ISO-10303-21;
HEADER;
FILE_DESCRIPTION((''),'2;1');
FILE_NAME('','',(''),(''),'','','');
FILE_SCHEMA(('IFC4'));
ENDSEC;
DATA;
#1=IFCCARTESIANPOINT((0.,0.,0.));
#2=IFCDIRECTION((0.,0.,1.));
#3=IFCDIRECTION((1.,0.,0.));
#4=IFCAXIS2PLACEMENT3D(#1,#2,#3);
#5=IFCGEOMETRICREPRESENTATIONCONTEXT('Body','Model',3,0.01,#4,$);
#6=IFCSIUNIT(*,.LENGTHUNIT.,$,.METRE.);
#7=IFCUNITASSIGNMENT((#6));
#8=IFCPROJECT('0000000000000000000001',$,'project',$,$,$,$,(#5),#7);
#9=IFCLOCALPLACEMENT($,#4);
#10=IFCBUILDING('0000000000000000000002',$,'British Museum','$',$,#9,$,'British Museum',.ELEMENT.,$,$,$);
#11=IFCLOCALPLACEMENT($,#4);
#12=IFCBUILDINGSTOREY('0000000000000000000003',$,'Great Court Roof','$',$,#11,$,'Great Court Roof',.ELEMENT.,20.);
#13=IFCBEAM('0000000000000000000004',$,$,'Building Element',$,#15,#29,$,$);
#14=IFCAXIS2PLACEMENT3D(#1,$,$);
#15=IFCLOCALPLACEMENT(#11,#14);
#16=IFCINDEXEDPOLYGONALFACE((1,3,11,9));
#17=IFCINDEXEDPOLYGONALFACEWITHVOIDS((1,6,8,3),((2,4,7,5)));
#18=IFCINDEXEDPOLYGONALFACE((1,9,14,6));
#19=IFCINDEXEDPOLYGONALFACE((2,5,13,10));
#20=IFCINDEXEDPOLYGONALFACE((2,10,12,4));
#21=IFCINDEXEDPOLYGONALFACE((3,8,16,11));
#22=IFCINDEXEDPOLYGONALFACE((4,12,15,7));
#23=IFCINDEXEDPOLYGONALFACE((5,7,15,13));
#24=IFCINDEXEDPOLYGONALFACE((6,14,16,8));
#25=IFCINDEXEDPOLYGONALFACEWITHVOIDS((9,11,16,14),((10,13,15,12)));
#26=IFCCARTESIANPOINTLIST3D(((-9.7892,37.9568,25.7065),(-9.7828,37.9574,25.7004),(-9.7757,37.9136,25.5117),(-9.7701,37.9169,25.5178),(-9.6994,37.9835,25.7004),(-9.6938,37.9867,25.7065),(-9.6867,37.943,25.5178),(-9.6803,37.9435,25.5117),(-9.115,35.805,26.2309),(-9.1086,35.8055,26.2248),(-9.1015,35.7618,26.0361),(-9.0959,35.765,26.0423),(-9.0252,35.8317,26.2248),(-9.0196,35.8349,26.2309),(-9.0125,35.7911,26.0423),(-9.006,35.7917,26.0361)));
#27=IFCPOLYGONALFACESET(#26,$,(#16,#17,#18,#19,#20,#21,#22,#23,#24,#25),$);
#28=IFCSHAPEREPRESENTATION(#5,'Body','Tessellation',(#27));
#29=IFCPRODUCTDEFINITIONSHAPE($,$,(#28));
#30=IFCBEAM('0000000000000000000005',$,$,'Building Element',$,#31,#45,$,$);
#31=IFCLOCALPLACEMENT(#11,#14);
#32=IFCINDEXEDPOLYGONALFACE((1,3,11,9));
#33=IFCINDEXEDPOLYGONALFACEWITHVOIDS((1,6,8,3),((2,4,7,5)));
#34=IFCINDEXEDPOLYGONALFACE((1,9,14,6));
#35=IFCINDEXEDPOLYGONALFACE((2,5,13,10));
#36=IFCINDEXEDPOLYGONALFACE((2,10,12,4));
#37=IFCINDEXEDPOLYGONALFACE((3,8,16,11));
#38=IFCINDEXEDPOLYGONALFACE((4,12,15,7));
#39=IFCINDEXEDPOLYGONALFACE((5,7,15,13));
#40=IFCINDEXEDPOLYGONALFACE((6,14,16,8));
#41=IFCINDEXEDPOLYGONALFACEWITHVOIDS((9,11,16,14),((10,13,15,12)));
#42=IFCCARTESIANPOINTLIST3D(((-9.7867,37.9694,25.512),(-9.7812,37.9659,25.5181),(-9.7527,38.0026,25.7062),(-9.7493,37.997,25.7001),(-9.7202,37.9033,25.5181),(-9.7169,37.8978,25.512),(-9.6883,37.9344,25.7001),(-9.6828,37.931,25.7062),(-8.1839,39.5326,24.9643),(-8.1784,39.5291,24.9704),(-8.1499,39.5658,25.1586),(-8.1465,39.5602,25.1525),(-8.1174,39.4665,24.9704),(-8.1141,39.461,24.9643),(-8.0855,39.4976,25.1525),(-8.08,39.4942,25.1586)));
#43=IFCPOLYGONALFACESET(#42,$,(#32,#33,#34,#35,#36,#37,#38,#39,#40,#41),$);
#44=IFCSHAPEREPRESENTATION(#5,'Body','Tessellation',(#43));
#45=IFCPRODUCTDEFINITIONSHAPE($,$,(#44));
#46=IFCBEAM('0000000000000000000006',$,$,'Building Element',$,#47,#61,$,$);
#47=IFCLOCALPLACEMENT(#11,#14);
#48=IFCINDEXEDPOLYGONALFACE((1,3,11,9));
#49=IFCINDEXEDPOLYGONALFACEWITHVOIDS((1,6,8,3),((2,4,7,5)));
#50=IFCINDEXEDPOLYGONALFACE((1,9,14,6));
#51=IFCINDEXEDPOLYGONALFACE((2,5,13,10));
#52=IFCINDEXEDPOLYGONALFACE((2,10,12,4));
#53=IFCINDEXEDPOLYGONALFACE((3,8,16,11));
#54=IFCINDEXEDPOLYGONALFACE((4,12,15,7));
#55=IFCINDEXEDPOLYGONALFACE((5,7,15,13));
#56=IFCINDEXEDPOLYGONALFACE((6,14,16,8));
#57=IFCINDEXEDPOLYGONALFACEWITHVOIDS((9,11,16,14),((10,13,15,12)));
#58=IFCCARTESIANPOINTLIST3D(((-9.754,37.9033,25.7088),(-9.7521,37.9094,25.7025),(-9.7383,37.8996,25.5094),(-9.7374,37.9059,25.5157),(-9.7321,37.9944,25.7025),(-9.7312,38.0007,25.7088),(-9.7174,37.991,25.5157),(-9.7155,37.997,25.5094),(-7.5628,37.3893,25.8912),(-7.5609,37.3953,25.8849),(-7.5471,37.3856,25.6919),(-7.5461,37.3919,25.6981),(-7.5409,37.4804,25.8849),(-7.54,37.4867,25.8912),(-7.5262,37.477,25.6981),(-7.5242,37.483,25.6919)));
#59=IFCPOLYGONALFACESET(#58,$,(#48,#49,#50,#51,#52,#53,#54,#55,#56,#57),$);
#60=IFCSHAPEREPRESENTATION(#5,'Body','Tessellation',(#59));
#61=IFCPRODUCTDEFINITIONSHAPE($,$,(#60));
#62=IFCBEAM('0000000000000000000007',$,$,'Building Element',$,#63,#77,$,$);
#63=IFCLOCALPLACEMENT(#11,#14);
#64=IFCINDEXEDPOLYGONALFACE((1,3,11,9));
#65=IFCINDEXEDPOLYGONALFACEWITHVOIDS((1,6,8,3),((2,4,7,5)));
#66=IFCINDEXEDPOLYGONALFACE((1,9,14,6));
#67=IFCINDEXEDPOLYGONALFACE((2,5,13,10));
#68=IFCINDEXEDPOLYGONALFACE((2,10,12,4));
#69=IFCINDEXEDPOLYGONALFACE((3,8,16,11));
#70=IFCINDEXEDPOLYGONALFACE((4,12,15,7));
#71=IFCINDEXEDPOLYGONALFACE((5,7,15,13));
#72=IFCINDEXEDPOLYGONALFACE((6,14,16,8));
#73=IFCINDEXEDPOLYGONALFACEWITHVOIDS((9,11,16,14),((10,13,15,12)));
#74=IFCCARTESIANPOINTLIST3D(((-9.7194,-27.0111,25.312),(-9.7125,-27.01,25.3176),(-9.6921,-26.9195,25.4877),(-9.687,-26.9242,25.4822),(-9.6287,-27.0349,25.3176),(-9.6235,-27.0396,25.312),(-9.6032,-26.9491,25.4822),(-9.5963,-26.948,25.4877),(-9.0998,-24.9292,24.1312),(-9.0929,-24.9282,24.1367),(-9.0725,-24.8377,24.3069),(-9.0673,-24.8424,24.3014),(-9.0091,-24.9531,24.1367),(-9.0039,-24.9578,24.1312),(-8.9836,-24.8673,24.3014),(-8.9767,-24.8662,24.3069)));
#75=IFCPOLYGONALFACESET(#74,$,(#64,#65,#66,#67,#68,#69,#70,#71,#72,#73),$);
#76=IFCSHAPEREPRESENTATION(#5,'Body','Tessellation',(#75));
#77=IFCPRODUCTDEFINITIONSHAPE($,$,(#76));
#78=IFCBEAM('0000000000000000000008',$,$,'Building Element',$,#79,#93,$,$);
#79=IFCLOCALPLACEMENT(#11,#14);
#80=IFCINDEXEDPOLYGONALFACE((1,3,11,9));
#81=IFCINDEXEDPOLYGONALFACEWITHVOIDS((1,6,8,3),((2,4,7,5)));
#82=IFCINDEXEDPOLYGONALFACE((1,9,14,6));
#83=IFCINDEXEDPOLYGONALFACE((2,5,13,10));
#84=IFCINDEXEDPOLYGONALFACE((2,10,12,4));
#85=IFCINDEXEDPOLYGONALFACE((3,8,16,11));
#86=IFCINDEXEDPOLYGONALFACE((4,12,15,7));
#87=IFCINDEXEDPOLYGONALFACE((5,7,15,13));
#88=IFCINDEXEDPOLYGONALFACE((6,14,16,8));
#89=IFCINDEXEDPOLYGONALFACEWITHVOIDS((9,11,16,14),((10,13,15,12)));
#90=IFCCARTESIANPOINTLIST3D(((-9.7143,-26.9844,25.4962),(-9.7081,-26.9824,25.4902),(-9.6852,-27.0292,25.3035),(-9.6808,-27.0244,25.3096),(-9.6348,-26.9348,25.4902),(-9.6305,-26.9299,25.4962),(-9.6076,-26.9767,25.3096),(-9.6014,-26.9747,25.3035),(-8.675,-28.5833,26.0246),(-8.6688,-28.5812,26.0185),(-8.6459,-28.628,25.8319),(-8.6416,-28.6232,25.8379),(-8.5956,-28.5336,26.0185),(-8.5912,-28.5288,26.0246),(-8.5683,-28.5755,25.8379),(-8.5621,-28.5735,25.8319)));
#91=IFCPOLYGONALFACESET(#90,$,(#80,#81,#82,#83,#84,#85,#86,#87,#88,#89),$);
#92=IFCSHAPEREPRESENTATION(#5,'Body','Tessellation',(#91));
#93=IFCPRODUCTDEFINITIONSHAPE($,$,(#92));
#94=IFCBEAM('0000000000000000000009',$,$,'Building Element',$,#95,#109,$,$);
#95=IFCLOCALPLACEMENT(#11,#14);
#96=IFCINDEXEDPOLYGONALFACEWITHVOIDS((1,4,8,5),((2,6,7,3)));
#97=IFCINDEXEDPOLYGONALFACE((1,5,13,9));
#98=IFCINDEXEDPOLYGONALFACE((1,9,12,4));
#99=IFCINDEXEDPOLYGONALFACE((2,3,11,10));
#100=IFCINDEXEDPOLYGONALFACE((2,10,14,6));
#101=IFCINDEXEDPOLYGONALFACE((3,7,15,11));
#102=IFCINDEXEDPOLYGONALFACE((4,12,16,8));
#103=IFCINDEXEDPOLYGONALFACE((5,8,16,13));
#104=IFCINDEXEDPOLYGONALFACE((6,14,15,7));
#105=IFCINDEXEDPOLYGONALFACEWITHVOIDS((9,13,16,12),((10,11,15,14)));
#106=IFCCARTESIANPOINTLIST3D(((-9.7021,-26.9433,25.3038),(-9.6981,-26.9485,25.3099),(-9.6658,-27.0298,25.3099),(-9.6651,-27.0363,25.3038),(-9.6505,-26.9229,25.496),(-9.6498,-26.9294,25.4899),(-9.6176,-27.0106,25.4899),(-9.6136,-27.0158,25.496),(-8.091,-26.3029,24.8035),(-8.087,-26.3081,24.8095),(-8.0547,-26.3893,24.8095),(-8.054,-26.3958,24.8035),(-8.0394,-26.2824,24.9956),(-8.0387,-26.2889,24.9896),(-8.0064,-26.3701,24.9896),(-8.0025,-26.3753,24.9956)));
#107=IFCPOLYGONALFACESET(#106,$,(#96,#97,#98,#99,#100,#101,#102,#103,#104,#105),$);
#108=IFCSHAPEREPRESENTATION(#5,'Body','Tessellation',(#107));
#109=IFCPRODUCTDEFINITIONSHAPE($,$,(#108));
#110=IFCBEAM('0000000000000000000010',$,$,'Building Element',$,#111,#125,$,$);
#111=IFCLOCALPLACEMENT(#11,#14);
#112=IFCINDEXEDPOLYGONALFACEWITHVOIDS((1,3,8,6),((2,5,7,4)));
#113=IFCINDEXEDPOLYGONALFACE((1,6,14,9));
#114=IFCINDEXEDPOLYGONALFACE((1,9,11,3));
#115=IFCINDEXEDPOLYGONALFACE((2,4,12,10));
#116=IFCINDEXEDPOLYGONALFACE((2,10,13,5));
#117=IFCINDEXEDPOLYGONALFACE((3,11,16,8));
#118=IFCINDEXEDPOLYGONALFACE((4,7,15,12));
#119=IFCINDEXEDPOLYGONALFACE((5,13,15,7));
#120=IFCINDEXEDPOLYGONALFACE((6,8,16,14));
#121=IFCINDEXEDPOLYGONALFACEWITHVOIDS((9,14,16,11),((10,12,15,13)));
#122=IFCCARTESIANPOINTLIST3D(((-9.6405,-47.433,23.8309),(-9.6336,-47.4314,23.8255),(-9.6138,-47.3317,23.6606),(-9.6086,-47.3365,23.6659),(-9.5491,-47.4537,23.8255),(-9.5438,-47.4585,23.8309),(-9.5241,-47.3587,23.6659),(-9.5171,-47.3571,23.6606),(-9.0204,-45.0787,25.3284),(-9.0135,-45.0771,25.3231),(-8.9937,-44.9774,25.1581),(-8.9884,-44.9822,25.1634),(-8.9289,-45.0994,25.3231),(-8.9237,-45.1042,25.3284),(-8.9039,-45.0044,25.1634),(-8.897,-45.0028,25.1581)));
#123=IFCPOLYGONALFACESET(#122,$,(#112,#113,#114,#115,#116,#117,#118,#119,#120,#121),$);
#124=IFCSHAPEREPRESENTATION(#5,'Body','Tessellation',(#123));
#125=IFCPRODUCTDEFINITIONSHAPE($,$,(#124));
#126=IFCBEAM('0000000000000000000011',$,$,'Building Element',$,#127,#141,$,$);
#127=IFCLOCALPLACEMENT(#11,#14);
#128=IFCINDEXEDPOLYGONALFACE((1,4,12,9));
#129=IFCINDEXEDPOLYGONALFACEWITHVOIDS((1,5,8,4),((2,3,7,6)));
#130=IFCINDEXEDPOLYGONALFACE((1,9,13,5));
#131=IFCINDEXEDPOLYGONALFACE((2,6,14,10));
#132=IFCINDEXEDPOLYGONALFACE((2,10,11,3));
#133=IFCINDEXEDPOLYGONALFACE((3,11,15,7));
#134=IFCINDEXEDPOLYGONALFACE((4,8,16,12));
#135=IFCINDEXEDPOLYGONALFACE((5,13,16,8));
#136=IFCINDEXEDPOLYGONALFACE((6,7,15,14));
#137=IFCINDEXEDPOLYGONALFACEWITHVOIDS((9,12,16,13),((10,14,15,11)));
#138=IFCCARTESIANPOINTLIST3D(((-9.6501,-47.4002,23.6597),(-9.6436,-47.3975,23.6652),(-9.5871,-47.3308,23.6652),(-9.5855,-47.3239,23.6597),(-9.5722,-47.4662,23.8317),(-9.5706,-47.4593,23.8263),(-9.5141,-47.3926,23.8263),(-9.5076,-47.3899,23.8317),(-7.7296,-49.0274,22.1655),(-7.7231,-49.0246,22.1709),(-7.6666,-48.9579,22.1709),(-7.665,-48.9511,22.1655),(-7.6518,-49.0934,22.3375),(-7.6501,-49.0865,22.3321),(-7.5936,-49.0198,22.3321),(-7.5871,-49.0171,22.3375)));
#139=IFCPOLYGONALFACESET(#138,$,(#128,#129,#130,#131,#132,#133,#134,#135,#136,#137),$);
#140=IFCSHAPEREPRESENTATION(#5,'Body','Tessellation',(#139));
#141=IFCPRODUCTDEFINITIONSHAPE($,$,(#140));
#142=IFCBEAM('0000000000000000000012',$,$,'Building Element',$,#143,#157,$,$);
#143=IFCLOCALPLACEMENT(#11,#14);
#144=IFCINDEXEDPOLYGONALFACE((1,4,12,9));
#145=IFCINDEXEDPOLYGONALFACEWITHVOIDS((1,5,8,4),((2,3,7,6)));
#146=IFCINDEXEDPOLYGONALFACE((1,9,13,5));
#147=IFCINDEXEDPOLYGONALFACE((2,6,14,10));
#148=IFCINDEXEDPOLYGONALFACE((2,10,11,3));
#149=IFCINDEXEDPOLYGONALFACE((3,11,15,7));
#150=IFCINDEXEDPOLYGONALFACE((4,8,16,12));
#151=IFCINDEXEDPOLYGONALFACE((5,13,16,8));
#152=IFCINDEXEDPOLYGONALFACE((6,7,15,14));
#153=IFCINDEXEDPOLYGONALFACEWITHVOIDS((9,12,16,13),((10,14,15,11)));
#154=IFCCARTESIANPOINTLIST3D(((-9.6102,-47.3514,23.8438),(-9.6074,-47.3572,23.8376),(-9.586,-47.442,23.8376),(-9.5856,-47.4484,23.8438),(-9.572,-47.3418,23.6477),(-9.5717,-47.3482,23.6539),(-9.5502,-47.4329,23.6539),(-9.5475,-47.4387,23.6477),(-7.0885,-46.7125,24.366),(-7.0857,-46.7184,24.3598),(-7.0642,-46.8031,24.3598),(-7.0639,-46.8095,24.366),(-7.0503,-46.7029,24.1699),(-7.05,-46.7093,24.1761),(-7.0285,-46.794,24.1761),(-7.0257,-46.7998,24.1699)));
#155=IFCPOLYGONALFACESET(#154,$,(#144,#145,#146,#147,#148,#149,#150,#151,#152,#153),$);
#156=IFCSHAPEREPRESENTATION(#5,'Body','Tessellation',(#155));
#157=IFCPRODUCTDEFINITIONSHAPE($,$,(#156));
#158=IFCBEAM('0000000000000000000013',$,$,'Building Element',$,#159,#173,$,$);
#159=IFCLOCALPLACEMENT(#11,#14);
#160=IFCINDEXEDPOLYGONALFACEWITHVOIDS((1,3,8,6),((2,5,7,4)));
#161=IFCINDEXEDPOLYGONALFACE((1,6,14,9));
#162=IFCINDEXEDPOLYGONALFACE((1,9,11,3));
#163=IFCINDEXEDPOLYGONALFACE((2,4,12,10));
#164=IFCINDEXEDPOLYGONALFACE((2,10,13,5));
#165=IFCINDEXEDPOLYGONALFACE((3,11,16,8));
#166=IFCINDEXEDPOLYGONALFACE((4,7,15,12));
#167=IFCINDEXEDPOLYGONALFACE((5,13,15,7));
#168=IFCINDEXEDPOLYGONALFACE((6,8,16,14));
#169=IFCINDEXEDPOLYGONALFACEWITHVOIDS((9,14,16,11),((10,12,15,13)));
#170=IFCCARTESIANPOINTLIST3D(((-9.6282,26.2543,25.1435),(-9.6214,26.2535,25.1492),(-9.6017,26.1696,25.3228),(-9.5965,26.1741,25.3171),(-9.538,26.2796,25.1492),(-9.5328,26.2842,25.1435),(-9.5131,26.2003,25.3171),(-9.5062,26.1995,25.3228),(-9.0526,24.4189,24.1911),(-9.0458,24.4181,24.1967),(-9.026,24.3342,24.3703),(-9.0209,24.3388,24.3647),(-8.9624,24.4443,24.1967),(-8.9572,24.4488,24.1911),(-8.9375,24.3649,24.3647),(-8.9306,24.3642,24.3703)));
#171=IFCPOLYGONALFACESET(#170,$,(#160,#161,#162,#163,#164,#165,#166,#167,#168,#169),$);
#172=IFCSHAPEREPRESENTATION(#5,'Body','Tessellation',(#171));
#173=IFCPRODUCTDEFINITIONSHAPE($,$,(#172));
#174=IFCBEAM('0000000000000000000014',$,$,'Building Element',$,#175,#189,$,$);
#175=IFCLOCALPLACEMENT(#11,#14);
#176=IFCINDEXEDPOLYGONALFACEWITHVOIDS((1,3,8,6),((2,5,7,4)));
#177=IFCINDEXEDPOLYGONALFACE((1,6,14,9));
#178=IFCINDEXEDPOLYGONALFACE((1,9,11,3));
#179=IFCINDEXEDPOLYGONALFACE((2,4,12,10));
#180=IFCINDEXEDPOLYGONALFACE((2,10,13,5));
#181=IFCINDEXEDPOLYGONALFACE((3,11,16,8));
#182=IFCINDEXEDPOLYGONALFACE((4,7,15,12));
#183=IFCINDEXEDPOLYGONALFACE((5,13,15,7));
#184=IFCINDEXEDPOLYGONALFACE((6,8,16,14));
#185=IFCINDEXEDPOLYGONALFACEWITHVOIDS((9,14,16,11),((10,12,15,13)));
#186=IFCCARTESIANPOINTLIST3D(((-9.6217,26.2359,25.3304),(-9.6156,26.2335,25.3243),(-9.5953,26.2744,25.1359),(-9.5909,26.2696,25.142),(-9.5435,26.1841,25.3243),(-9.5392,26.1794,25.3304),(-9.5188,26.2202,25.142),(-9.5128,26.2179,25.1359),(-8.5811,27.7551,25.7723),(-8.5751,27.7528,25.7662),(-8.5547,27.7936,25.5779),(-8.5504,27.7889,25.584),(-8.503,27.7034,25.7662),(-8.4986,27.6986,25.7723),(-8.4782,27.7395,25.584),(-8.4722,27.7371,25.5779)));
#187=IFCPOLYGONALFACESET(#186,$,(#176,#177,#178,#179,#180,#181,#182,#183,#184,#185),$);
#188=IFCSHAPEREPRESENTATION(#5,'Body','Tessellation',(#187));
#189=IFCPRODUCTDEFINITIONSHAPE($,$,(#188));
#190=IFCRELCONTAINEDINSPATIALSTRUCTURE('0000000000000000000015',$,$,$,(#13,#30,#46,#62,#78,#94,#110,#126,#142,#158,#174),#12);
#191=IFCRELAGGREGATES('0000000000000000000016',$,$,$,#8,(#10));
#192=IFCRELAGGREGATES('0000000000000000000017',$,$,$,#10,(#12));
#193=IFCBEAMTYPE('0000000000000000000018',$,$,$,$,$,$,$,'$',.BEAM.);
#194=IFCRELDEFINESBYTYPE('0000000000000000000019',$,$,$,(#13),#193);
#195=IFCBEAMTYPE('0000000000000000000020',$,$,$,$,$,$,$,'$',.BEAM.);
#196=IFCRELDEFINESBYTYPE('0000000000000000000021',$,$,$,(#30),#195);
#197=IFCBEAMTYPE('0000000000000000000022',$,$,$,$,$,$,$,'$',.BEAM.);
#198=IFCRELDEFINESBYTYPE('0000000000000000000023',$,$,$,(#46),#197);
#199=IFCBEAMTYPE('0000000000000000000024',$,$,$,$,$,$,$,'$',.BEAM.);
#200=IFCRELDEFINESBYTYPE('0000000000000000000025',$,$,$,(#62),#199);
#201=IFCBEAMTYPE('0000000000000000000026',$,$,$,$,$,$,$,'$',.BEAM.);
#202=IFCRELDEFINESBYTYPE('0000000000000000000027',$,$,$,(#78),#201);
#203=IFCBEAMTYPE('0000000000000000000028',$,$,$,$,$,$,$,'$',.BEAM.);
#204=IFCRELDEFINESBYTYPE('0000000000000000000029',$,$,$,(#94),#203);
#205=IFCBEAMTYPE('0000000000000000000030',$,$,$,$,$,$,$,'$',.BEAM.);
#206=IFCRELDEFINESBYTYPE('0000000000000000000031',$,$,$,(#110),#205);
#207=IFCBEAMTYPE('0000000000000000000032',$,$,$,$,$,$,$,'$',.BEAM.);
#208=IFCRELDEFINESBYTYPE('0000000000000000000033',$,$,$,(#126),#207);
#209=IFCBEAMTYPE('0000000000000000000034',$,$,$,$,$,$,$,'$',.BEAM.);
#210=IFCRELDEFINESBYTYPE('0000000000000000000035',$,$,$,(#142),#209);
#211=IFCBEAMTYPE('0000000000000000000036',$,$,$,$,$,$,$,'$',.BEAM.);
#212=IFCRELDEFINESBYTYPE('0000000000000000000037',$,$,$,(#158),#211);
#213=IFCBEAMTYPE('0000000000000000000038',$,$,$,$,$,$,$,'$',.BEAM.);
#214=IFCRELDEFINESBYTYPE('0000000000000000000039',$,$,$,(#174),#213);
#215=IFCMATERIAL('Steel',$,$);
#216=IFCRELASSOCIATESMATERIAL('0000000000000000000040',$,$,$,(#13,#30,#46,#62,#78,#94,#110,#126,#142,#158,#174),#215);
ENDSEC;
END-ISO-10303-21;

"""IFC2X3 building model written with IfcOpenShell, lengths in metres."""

from ifc_helpers import new_model, si_unit, frame, origin_with_axes, origin_2d, place, context, project, spatial, hollow_rectangle, extrude, material, type_object, element, save


model = new_model("IFC2X3")

# Units and contexts
model_context = context("Model", 3, precision=0.01, world=origin_with_axes(), identifier="Body")
ifc_project = project(units=[si_unit("LENGTHUNIT", "METRE")], contexts=[model_context])

# Building, storey
building_placement = place(None, origin_with_axes())
building = spatial("IfcBuilding", under=ifc_project, at=building_placement, Name="British Museum", Description="$", LongName="British Museum", CompositionType="ELEMENT")
storey_placement = place(None, origin_with_axes())
storey = spatial("IfcBuildingStorey", under=building, at=storey_placement, Name="Great Court Roof", Description="$", LongName="Great Court Roof", CompositionType="ELEMENT", Elevation=20.0)

# Beams
ifc_material = material(Name="Steel")
beam_type_1 = type_object("IfcBeamType", ElementType="$", PredefinedType="BEAM")
beam_1_placement = place(None, origin_with_axes())
element("IfcBeam", 1, at=beam_1_placement, inside=storey, type_object=beam_type_1, material=ifc_material, Description="Building Element", context=model_context, shape_type="SweptSolid", body=[
    extrude(hollow_rectangle(XDim=0.1, YDim=0.2, WallThickness=0.0063, InnerFilletRadius=-0.0063, OuterFilletRadius=0.0, at=origin_2d()), frame((-9.7348, 37.9502, 25.6091), z_axis=(0.291229, -0.92945, 0.226512), x_axis=(0.954253, 0.299001, 0.0)), (0.0, 0.0, 1.0), 2.3152),
])
beam_type_2 = type_object("IfcBeamType", ElementType="$", PredefinedType="BEAM")
beam_2_placement = place(None, origin_with_axes())
element("IfcBeam", 2, at=beam_2_placement, inside=storey, type_object=beam_type_2, material=ifc_material, Description="Building Element", context=model_context, shape_type="SweptSolid", body=[
    extrude(hollow_rectangle(XDim=0.1, YDim=0.2, WallThickness=0.0063, InnerFilletRadius=-0.0063, OuterFilletRadius=0.0, at=origin_2d()), frame((-9.7348, 37.9502, 25.6091), z_axis=(0.695394, 0.67821, -0.237611), x_axis=(-0.698206, 0.715897, 0.0)), (0.0, 0.0, 1.0), 2.3049),
])
beam_type_3 = type_object("IfcBeamType", ElementType="$", PredefinedType="BEAM")
beam_3_placement = place(None, origin_with_axes())
element("IfcBeam", 3, at=beam_3_placement, inside=storey, type_object=beam_type_3, material=ifc_material, Description="Building Element", context=model_context, shape_type="SweptSolid", body=[
    extrude(hollow_rectangle(XDim=0.1, YDim=0.2, WallThickness=0.0063, InnerFilletRadius=-0.0063, OuterFilletRadius=0.0, at=origin_2d()), frame((-9.7348, 37.9502, 25.6091), z_axis=(0.970391, -0.227631, 0.080786), x_axis=(0.228377, 0.973573, 0.0)), (0.0, 0.0, 1.0), 2.2581),
])
beam_type_4 = type_object("IfcBeamType", ElementType="$", PredefinedType="BEAM")
beam_4_placement = place(None, origin_with_axes())
element("IfcBeam", 4, at=beam_4_placement, inside=storey, type_object=beam_type_4, material=ifc_material, Description="Building Element", context=model_context, shape_type="SweptSolid", body=[
    extrude(hollow_rectangle(XDim=0.1, YDim=0.2, WallThickness=0.0063, InnerFilletRadius=-0.0063, OuterFilletRadius=0.0, at=origin_2d()), frame((-9.6578, -26.9796, 25.3999), z_axis=(0.250628, 0.842057, -0.477626), x_axis=(-0.958447, 0.28527, 0.0)), (0.0, 0.0, 1.0), 2.4723),
])
beam_type_5 = type_object("IfcBeamType", ElementType="$", PredefinedType="BEAM")
beam_5_placement = place(None, origin_with_axes())
element("IfcBeam", 5, at=beam_5_placement, inside=storey, type_object=beam_type_5, material=ifc_material, Description="Building Element", context=model_context, shape_type="SweptSolid", body=[
    extrude(hollow_rectangle(XDim=0.1, YDim=0.2, WallThickness=0.0063, InnerFilletRadius=-0.0063, OuterFilletRadius=0.0, at=origin_2d()), frame((-9.6578, -26.9796, 25.3999), z_axis=(0.525218, -0.807992, 0.267011), x_axis=(0.838432, 0.545006, 0.0)), (0.0, 0.0, 1.0), 1.9788),
])
beam_type_6 = type_object("IfcBeamType", ElementType="$", PredefinedType="BEAM")
beam_6_placement = place(None, origin_with_axes())
element("IfcBeam", 6, at=beam_6_placement, inside=storey, type_object=beam_type_6, material=ifc_material, Description="Building Element", context=model_context, shape_type="SweptSolid", body=[
    extrude(hollow_rectangle(XDim=0.1, YDim=0.2, WallThickness=0.0063, InnerFilletRadius=-0.0063, OuterFilletRadius=0.0, at=origin_2d()), frame((-9.6578, -26.9796, 25.3999), z_axis=(0.892829, 0.354939, -0.277265), x_axis=(-0.369422, 0.929262, 0.0)), (0.0, 0.0, 1.0), 1.8045),
])
beam_type_7 = type_object("IfcBeamType", ElementType="$", PredefinedType="BEAM")
beam_7_placement = place(None, origin_with_axes())
element("IfcBeam", 7, at=beam_7_placement, inside=storey, type_object=beam_type_7, material=ifc_material, Description="Building Element", context=model_context, shape_type="SweptSolid", body=[
    extrude(hollow_rectangle(XDim=0.1, YDim=0.2, WallThickness=0.0063, InnerFilletRadius=-0.0063, OuterFilletRadius=0.0, at=origin_2d()), frame((-9.5788, -47.3951, 23.7457), z_axis=(0.216961, 0.823674, 0.523916), x_axis=(-0.967015, 0.254718, 0.0)), (0.0, 0.0, 1.0), 2.8583),
])
beam_type_8 = type_object("IfcBeamType", ElementType="$", PredefinedType="BEAM")
beam_8_placement = place(None, origin_with_axes())
element("IfcBeam", 8, at=beam_8_placement, inside=storey, type_object=beam_type_8, material=ifc_material, Description="Building Element", context=model_context, shape_type="SweptSolid", body=[
    extrude(hollow_rectangle(XDim=0.1, YDim=0.2, WallThickness=0.0063, InnerFilletRadius=-0.0063, OuterFilletRadius=0.0, at=origin_2d()), frame((-9.5788, -47.3951, 23.7457), z_axis=(0.656072, -0.555871, -0.510467), x_axis=(0.646439, 0.762966, 0.0)), (0.0, 0.0, 1.0), 2.9272),
])
beam_type_9 = type_object("IfcBeamType", ElementType="$", PredefinedType="BEAM")
beam_9_placement = place(None, origin_with_axes())
element("IfcBeam", 9, at=beam_9_placement, inside=storey, type_object=beam_type_9, material=ifc_material, Description="Building Element", context=model_context, shape_type="SweptSolid", body=[
    extrude(hollow_rectangle(XDim=0.1, YDim=0.2, WallThickness=0.0063, InnerFilletRadius=-0.0063, OuterFilletRadius=0.0, at=origin_2d()), frame((-9.5788, -47.3951, 23.7457), z_axis=(0.950415, 0.240787, 0.196807), x_axis=(-0.24559, 0.969374, 0.0)), (0.0, 0.0, 1.0), 2.6533),
])
beam_type_10 = type_object("IfcBeamType", ElementType="$", PredefinedType="BEAM")
beam_10_placement = place(None, origin_with_axes())
element("IfcBeam", 10, at=beam_10_placement, inside=storey, type_object=beam_type_10, material=ifc_material, Description="Building Element", context=model_context, shape_type="SweptSolid", body=[
    extrude(hollow_rectangle(XDim=0.1, YDim=0.2, WallThickness=0.0063, InnerFilletRadius=-0.0063, OuterFilletRadius=0.0, at=origin_2d()), frame((-9.5672, 26.2269, 25.2331), z_axis=(0.268178, -0.855088, -0.44374), x_axis=(0.954174, 0.299254, 0.0)), (0.0, 0.0, 1.0), 2.1464),
])
beam_type_11 = type_object("IfcBeamType", ElementType="$", PredefinedType="BEAM")
beam_11_placement = place(None, origin_with_axes())
element("IfcBeam", 11, at=beam_11_placement, inside=storey, type_object=beam_type_11, material=ifc_material, Description="Building Element", context=model_context, shape_type="SweptSolid", body=[
    extrude(hollow_rectangle(XDim=0.1, YDim=0.2, WallThickness=0.0063, InnerFilletRadius=-0.0063, OuterFilletRadius=0.0, at=origin_2d()), frame((-9.5672, 26.2269, 25.2331), z_axis=(0.549481, 0.802249, 0.233382), x_axis=(-0.825032, 0.565086, 0.0)), (0.0, 0.0, 1.0), 1.8937),
])

save(model, "model.ifc")
